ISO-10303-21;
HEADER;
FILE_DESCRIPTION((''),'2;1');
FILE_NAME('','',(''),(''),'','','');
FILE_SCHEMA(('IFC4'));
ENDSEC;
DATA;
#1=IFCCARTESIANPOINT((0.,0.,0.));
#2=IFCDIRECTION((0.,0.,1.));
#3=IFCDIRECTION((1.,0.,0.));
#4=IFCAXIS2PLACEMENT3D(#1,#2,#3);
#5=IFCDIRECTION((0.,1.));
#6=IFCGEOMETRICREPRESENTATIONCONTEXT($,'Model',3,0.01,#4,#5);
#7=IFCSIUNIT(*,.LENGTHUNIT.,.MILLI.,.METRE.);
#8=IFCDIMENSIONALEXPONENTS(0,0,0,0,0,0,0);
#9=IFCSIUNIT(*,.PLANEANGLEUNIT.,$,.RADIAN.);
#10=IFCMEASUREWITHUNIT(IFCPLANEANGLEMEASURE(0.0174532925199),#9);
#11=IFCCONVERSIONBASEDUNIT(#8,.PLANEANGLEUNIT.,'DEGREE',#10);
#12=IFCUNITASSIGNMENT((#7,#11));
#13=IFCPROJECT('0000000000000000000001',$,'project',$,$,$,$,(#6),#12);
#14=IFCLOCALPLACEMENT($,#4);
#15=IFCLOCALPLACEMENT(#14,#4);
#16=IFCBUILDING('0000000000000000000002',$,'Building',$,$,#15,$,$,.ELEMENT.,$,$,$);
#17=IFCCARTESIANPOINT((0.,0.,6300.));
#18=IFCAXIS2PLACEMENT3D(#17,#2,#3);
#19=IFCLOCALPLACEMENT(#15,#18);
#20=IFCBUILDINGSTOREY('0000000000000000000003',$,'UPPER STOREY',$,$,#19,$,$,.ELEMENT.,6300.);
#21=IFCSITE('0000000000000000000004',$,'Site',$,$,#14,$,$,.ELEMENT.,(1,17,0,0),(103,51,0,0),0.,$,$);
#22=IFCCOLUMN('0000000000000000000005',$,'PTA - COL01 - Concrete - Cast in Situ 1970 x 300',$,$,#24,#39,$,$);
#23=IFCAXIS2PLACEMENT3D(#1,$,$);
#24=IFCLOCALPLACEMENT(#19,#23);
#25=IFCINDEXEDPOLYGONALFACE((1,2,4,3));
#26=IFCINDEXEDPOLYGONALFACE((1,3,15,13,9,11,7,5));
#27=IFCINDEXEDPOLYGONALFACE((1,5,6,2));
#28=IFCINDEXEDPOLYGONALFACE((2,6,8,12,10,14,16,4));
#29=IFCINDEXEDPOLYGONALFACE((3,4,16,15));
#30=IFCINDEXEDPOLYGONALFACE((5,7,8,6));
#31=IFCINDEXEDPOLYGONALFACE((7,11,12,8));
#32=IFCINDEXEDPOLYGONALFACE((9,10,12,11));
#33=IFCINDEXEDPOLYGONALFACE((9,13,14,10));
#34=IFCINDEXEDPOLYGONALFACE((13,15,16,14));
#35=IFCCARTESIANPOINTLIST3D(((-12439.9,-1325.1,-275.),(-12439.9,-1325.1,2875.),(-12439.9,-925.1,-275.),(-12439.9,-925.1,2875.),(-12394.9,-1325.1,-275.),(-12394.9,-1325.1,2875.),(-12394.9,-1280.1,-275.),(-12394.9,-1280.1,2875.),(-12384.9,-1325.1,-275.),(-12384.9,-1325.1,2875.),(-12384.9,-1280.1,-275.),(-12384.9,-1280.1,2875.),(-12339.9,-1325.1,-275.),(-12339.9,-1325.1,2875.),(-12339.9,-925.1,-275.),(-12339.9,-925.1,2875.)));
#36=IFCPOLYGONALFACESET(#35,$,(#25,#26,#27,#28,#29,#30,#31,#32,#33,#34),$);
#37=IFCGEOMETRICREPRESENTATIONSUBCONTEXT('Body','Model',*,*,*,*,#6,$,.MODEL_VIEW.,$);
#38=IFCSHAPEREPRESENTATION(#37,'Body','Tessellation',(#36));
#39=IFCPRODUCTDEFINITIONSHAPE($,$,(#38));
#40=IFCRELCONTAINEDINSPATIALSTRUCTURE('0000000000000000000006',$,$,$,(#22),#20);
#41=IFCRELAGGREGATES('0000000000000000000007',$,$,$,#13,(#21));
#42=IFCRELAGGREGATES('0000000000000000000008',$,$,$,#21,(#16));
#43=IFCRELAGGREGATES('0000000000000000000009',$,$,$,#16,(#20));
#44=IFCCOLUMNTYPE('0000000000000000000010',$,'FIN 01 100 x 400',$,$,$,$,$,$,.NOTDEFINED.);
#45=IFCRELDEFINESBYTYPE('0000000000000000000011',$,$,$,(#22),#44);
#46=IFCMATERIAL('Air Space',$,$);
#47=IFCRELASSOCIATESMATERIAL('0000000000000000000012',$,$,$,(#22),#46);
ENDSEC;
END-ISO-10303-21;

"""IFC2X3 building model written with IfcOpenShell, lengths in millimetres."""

from ifc_helpers import new_model, entity, si_unit, converted_unit, direction, frame, origin_with_axes, place, context, subcontext, project, spatial, polyline, outline, extrude, material, type_object, element, save


model = new_model("IFC2X3")

# Units and contexts
model_context = context("Model", 3, precision=0.01, world=origin_with_axes(), true_north=direction((0.0, 1.0)))
body_context = subcontext(model_context, "Body", "Model", "MODEL_VIEW")
ifc_project = project(units=[si_unit("LENGTHUNIT", "METRE", prefix="MILLI"), converted_unit("PLANEANGLEUNIT", "DEGREE", entity("IfcPlaneAngleMeasure", 0.0174532925199), si_unit("PLANEANGLEUNIT", "RADIAN"), dimensions=[0, 0, 0, 0, 0, 0, 0])], contexts=[model_context])

# Site, building, storey
site_placement = place(None, origin_with_axes())
site = spatial("IfcSite", under=ifc_project, at=site_placement, Name="Site", CompositionType="ELEMENT", RefLatitude=(1, 17, 0, 0), RefLongitude=(103, 51, 0, 0), RefElevation=0.0)
building_placement = place(site_placement, origin_with_axes())
building = spatial("IfcBuilding", under=site, at=building_placement, Name="Building", CompositionType="ELEMENT")
storey_placement = place(building_placement, frame((0.0, 0.0, 6300.0), z_axis=(0.0, 0.0, 1.0), x_axis=(1.0, 0.0, 0.0)))
storey = spatial("IfcBuildingStorey", under=building, at=storey_placement, Name="UPPER STOREY", CompositionType="ELEMENT", Elevation=6300.0)

# Column
ifc_material_1 = material(Name="Air Space")
column_type = type_object("IfcColumnType", Name="FIN 01 100 x 400", PredefinedType="NOTDEFINED")
column_placement = place(storey_placement, frame((-12389.9, -1325.1, -275.0), z_axis=(0.0, 0.0, 1.0), x_axis=(-1.0, 0.0, 0.0)))
element("IfcColumn", 1, at=column_placement, inside=storey, type_object=column_type, material=ifc_material_1, Name="PTA - COL01 - Concrete - Cast in Situ 1970 x 300", context=body_context, shape_type="SweptSolid", body=[
    extrude(outline(polyline([(-50.0, 0.0), (-50.0, -400.0), (50.0, -400.0), (50.0, 0.0), (5.0, 0.0), (5.0, -45.0), (-5.0, -45.0), (-5.0, 0.0), (-50.0, 0.0)])), frame((0.0, 0.0, 0.0), z_axis=(0.0, 0.0, -1.0), x_axis=(-1.0, 0.0, 0.0)), (0.0, 0.0, -1.0), 3150.0),
])

save(model, "model.ifc")
